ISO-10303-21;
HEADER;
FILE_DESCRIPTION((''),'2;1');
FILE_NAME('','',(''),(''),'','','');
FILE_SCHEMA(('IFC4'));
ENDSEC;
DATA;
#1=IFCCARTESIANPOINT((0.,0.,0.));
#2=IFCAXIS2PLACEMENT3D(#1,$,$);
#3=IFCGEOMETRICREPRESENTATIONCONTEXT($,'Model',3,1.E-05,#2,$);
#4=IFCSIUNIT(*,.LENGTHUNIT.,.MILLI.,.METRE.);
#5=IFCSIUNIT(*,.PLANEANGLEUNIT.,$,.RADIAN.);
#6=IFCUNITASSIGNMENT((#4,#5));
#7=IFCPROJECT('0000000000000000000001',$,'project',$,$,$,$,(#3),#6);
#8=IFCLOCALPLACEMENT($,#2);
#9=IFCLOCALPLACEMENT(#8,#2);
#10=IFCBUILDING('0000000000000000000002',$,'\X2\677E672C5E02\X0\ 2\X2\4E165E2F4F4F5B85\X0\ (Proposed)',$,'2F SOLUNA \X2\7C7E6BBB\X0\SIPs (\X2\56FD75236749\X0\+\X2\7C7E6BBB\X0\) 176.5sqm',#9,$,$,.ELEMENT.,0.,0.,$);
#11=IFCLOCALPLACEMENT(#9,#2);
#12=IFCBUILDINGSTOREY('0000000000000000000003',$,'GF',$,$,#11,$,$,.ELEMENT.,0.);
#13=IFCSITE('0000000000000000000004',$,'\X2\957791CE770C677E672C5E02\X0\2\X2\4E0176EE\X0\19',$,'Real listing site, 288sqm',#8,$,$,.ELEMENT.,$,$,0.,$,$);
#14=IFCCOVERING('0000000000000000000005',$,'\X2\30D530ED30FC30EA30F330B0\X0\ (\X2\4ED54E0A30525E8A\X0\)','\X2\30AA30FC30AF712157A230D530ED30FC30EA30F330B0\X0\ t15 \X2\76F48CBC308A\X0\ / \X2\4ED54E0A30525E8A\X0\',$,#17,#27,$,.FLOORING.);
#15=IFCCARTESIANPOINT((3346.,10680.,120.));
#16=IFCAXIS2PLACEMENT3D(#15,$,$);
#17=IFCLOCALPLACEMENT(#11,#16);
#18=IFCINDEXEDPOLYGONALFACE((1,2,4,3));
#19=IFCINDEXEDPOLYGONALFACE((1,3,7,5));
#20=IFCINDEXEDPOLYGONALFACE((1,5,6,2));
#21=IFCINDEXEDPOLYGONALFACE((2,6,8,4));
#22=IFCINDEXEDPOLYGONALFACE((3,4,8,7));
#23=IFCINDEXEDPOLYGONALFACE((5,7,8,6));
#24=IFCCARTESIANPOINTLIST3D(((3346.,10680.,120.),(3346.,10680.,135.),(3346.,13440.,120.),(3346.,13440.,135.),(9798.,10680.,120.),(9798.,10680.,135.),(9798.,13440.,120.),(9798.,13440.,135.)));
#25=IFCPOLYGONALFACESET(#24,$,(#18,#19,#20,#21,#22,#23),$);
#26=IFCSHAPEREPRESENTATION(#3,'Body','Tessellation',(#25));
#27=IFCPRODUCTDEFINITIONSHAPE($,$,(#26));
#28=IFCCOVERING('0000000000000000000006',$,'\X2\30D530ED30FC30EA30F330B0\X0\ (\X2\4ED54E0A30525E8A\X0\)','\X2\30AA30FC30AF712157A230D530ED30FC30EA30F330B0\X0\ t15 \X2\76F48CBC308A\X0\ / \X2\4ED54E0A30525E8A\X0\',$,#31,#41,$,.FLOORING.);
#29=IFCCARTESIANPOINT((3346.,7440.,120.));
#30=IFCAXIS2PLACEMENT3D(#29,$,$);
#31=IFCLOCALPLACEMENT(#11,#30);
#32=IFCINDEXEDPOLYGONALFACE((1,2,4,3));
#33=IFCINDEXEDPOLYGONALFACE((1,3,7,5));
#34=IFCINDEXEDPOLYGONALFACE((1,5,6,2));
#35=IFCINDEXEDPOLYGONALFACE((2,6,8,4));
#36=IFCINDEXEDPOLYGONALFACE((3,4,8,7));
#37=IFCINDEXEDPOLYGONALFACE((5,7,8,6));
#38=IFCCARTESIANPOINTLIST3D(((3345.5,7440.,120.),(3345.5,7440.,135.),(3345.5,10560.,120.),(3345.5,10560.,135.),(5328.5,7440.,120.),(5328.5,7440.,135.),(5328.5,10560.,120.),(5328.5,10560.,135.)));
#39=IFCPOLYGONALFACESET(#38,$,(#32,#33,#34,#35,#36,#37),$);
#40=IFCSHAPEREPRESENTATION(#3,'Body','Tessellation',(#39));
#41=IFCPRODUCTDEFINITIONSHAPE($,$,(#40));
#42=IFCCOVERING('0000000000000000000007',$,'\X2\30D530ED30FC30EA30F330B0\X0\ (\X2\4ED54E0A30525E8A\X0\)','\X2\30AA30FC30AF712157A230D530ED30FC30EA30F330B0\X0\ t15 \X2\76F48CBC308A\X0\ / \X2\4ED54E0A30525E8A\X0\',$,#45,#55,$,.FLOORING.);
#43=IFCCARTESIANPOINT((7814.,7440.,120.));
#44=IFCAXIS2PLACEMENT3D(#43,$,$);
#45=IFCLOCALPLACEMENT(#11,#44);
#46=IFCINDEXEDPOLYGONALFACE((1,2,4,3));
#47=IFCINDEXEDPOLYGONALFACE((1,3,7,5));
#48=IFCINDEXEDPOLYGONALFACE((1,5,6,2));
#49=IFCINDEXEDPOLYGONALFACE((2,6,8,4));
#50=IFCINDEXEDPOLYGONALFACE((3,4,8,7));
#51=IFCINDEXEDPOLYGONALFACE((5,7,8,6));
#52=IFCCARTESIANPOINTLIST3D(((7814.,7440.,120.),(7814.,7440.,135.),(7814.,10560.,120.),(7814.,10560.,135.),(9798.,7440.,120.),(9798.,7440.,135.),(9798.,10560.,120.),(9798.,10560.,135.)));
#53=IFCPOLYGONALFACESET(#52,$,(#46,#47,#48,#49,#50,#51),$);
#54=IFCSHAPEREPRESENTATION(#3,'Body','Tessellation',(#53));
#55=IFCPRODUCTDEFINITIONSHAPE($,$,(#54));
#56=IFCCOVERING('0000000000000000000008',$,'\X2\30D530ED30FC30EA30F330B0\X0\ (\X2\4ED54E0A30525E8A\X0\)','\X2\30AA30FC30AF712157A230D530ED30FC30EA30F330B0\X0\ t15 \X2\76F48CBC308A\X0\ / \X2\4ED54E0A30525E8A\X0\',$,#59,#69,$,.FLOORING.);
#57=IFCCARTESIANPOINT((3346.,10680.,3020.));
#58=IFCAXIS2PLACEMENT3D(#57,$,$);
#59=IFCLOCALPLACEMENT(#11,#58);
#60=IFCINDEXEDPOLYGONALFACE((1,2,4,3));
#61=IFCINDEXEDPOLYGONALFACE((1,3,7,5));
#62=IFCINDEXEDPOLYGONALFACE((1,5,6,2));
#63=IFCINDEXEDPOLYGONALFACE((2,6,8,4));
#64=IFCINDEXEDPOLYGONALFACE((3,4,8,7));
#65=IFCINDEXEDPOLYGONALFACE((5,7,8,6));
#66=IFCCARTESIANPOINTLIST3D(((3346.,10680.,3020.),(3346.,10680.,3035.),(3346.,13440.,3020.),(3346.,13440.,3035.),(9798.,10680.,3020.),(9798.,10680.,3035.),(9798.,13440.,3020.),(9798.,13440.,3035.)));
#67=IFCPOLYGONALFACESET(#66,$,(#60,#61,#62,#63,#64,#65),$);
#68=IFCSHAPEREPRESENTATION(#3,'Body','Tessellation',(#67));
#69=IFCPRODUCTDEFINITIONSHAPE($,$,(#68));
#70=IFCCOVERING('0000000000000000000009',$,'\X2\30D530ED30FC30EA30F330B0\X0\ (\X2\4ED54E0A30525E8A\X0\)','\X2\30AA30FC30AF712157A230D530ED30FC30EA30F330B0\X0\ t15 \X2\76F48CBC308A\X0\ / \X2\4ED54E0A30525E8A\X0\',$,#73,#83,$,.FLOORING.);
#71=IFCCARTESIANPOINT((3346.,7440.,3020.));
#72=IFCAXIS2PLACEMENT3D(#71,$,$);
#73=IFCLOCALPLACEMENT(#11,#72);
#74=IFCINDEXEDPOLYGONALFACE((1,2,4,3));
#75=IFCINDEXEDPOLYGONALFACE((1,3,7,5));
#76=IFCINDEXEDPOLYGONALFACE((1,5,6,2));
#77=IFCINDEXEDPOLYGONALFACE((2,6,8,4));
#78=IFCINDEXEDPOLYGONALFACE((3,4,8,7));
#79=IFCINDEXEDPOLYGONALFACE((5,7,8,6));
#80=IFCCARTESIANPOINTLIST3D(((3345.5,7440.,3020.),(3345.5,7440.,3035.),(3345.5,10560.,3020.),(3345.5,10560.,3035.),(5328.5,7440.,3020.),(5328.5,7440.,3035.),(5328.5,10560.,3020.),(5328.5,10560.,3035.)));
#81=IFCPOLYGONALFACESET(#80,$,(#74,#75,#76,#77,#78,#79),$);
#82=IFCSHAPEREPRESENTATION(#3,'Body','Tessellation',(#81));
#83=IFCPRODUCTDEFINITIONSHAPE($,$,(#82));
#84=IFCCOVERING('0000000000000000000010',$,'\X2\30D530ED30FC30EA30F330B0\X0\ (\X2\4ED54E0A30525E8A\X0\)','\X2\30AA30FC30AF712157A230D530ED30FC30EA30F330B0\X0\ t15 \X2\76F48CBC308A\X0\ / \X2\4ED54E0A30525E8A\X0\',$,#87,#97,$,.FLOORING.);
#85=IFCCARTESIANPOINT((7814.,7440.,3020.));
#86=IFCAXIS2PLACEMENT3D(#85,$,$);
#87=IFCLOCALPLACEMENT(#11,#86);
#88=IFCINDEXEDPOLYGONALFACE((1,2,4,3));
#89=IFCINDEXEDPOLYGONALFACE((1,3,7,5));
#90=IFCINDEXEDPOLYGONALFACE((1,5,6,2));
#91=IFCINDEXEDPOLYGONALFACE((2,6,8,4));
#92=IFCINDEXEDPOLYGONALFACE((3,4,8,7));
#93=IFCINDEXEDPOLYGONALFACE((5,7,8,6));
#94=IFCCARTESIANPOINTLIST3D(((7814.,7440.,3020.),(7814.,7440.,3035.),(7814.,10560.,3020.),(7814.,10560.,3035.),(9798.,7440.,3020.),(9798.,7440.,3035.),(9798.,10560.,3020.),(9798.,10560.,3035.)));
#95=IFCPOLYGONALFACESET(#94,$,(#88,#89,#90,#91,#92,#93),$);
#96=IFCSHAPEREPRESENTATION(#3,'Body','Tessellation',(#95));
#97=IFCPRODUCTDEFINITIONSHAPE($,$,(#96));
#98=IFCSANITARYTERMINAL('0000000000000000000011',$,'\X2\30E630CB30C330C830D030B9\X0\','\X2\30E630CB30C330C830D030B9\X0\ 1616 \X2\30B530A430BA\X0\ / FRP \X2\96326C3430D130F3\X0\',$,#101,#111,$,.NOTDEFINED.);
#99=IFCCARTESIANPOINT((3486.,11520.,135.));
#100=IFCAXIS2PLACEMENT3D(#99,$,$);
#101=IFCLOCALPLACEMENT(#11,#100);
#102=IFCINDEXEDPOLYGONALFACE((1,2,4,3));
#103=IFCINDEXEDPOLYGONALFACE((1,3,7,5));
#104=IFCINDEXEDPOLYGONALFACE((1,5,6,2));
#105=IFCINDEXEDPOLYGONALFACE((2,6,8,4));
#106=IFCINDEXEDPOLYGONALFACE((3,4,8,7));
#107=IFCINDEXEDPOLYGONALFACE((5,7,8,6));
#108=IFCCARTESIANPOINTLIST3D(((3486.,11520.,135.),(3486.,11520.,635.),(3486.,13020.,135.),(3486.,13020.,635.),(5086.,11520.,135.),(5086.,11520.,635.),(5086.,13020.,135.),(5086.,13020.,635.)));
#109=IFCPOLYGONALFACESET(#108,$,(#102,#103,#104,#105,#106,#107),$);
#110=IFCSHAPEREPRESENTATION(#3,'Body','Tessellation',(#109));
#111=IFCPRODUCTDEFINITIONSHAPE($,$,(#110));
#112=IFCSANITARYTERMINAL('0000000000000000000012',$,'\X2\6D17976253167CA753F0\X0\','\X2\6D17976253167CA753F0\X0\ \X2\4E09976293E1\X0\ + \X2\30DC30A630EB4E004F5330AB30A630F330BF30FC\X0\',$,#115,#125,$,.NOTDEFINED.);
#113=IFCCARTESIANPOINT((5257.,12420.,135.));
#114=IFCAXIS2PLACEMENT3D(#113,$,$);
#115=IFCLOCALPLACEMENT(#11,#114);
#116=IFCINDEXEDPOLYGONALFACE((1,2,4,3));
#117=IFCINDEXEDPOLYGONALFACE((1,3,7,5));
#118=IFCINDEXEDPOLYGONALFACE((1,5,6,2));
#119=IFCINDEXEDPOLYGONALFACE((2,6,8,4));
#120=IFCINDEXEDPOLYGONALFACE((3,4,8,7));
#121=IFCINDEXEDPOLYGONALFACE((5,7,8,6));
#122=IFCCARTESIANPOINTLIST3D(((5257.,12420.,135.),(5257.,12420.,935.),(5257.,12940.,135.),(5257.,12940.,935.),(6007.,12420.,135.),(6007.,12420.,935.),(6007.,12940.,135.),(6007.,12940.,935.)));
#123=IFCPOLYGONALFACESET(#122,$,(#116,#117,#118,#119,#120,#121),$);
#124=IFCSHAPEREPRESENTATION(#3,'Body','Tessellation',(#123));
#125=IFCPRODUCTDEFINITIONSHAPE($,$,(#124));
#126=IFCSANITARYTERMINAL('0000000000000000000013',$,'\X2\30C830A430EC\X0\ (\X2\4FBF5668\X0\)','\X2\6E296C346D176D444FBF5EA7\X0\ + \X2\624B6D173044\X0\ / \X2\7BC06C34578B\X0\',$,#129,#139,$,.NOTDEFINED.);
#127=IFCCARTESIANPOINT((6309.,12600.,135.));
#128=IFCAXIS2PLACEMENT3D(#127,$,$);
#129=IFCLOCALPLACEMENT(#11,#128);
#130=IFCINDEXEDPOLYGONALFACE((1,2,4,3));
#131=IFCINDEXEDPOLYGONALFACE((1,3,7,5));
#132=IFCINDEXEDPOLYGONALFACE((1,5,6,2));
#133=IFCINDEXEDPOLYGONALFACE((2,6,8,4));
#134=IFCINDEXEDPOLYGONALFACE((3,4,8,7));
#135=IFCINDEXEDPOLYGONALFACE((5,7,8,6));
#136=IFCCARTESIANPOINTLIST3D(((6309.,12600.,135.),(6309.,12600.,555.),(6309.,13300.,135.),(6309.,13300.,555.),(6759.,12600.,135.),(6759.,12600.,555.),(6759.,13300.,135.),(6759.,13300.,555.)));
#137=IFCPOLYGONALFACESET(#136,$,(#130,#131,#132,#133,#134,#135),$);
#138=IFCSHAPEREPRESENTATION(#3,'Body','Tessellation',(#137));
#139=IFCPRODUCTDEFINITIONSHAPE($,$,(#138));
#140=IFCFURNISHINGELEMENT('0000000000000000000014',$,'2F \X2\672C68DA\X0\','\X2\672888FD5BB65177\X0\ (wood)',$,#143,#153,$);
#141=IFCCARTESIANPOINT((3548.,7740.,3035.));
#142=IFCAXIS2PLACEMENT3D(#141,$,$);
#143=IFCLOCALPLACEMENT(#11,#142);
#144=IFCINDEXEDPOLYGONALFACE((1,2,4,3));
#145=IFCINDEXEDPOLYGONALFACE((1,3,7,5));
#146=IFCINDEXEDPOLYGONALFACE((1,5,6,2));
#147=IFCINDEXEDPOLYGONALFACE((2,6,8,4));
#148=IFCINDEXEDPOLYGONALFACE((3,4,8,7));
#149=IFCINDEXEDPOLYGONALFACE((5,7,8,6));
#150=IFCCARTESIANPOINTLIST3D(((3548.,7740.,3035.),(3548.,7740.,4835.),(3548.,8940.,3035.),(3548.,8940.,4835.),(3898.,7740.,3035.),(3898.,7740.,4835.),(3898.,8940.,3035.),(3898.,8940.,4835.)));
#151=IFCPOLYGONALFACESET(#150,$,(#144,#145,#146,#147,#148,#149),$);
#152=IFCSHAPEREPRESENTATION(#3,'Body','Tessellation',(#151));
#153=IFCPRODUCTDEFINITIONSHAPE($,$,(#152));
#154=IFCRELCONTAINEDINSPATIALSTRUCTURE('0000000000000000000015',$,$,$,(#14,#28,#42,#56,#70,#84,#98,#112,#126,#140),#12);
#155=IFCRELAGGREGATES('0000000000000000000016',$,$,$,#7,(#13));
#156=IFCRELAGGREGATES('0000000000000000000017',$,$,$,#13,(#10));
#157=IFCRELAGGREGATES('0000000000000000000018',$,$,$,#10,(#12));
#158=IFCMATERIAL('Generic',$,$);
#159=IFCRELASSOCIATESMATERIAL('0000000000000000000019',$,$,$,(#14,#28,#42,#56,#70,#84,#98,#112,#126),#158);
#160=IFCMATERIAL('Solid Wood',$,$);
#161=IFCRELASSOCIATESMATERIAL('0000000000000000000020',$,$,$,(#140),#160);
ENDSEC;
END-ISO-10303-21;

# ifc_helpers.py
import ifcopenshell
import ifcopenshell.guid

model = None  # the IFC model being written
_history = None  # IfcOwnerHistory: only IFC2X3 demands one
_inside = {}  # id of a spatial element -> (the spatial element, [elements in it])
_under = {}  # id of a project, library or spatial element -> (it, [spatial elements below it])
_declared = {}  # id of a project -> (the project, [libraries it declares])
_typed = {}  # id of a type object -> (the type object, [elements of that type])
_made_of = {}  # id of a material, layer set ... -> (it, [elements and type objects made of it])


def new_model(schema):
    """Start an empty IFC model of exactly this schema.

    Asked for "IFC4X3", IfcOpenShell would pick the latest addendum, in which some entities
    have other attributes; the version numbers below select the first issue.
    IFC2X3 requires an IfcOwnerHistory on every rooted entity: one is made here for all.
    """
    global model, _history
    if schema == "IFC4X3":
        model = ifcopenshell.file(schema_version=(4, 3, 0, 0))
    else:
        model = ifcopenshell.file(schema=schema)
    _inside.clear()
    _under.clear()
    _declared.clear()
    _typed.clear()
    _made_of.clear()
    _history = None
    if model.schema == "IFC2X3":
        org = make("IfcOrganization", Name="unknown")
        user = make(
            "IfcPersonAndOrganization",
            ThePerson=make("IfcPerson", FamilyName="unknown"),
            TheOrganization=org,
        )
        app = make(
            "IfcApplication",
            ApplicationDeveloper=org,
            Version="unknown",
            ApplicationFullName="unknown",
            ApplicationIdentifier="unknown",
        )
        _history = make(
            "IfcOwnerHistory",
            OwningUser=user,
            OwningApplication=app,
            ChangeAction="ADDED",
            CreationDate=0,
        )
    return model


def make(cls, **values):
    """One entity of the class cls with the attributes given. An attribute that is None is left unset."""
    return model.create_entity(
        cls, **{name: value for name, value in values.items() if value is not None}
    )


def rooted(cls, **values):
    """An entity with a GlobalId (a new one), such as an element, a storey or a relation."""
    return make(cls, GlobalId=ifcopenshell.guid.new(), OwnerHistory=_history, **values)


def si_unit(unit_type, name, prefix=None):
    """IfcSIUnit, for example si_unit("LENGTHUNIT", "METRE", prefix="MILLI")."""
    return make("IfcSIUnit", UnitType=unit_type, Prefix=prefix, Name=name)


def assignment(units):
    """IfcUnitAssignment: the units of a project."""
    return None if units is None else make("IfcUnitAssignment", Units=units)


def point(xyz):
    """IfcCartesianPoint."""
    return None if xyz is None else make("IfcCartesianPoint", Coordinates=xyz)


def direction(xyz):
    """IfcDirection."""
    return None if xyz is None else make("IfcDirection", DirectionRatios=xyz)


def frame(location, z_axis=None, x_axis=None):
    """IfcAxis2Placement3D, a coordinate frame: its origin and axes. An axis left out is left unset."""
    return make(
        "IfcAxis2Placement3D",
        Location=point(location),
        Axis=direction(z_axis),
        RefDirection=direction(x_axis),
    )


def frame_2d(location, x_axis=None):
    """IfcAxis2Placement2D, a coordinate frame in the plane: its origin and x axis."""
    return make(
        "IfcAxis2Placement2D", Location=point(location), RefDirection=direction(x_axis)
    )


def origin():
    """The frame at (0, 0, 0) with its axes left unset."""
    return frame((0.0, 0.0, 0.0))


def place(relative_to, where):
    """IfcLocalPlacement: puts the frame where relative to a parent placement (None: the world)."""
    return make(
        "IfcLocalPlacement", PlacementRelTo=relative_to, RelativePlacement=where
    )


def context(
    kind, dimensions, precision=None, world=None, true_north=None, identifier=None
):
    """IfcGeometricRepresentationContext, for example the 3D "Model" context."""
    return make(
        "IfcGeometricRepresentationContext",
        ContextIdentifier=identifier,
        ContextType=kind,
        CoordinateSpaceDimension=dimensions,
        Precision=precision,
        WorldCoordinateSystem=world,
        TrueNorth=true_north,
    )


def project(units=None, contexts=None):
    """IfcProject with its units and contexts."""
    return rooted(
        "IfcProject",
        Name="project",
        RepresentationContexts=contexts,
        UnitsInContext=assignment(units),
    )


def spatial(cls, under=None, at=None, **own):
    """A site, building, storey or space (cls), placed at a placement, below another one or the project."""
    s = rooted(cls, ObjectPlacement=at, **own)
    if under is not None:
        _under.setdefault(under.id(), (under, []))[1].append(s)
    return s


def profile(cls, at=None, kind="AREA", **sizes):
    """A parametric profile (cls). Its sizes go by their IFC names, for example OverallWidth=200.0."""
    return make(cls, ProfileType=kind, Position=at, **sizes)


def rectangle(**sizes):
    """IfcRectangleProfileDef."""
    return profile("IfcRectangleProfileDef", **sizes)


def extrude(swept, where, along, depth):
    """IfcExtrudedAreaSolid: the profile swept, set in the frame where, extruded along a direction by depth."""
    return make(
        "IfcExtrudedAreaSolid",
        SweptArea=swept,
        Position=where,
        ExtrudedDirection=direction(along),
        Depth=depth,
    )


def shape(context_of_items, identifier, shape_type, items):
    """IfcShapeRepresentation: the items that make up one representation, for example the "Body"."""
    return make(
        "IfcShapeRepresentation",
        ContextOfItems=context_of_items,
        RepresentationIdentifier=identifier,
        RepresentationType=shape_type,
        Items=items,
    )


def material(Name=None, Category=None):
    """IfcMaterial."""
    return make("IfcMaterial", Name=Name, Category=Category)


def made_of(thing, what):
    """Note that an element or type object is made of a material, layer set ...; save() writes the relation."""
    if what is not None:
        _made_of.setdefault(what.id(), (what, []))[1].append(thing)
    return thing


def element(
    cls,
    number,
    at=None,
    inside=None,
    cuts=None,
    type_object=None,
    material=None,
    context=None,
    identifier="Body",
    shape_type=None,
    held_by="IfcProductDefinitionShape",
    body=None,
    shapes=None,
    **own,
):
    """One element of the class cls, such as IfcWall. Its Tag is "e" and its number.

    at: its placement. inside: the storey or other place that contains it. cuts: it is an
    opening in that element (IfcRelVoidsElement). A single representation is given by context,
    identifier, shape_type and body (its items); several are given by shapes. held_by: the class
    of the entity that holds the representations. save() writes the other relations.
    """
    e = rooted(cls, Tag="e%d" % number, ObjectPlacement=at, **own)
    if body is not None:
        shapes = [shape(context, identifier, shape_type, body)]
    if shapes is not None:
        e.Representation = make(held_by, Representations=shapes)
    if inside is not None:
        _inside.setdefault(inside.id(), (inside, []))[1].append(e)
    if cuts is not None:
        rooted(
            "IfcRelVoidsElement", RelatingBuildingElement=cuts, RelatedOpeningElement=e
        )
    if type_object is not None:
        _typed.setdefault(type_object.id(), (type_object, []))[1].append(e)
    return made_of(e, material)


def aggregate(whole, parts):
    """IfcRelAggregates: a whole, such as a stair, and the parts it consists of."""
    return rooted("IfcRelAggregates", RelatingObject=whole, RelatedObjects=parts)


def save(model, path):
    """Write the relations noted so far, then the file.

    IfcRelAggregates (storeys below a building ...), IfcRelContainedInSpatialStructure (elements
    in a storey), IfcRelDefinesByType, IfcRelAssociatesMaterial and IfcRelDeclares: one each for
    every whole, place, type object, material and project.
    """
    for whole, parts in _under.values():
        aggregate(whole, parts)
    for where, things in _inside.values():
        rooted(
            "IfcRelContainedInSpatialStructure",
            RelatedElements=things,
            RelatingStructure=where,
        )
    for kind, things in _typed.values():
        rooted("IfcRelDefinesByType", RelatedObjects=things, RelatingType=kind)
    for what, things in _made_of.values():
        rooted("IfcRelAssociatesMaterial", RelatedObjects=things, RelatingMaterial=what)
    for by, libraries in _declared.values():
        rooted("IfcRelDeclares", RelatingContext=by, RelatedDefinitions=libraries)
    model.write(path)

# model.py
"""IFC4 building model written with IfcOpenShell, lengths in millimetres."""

from ifc_helpers import new_model, si_unit, frame, frame_2d, origin, place, context, project, spatial, rectangle, extrude, material, element, save


model = new_model("IFC4")

# Units and contexts
model_context = context("Model", 3, precision=1e-05, world=origin())
ifc_project = project(units=[si_unit("LENGTHUNIT", "METRE", prefix="MILLI"), si_unit("PLANEANGLEUNIT", "RADIAN")], contexts=[model_context])

# Site, building, storey
site_placement = place(None, origin())
site = spatial("IfcSite", under=ifc_project, at=site_placement, Name="長野県松本市2丁目19", ObjectType="Real listing site, 288sqm", CompositionType="ELEMENT", RefElevation=0.0)
building_placement = place(site_placement, origin())
building = spatial("IfcBuilding", under=site, at=building_placement, Name="松本市 2世帯住宅 (Proposed)", ObjectType="2F SOLUNA 籾殻SIPs (国産杉+籾殻) 176.5sqm", CompositionType="ELEMENT", ElevationOfRefHeight=0.0, ElevationOfTerrain=0.0)
storey_placement = place(building_placement, origin())
storey = spatial("IfcBuildingStorey", under=building, at=storey_placement, Name="GF", CompositionType="ELEMENT", Elevation=0.0)

# Shared definitions
ifc_material_1 = material(Name="Solid Wood")
ifc_material_2 = material(Name="Generic")

# Coverings
covering_1_placement = place(storey_placement, frame((3346.0, 10680.0, 120.0)))
element("IfcCovering", 1, at=covering_1_placement, inside=storey, material=ifc_material_2, Name="フローリング (仕上げ床)", Description="オーク無垢フローリング t15 直貼り / 仕上げ床", PredefinedType="FLOORING", context=model_context, shape_type="SweptSolid", body=[
    extrude(rectangle(XDim=6452.0, YDim=2760.0, at=frame_2d((3226.0, 1380.0))), frame((3346.0, 10680.0, 120.0)), (0.0, 0.0, 1.0), 15.0),
])
covering_2_placement = place(storey_placement, frame((3346.0, 7440.0, 120.0)))
element("IfcCovering", 2, at=covering_2_placement, inside=storey, material=ifc_material_2, Name="フローリング (仕上げ床)", Description="オーク無垢フローリング t15 直貼り / 仕上げ床", PredefinedType="FLOORING", context=model_context, shape_type="SweptSolid", body=[
    extrude(rectangle(XDim=1983.0, YDim=3120.0, at=frame_2d((991.0, 1560.0))), frame((3346.0, 7440.0, 120.0)), (0.0, 0.0, 1.0), 15.0),
])
covering_3_placement = place(storey_placement, frame((7814.0, 7440.0, 120.0)))
element("IfcCovering", 3, at=covering_3_placement, inside=storey, material=ifc_material_2, Name="フローリング (仕上げ床)", Description="オーク無垢フローリング t15 直貼り / 仕上げ床", PredefinedType="FLOORING", context=model_context, shape_type="SweptSolid", body=[
    extrude(rectangle(XDim=1984.0, YDim=3120.0, at=frame_2d((992.0, 1560.0))), frame((7814.0, 7440.0, 120.0)), (0.0, 0.0, 1.0), 15.0),
])
covering_4_placement = place(storey_placement, frame((3346.0, 10680.0, 3020.0)))
element("IfcCovering", 4, at=covering_4_placement, inside=storey, material=ifc_material_2, Name="フローリング (仕上げ床)", Description="オーク無垢フローリング t15 直貼り / 仕上げ床", PredefinedType="FLOORING", context=model_context, shape_type="SweptSolid", body=[
    extrude(rectangle(XDim=6452.0, YDim=2760.0, at=frame_2d((3226.0, 1380.0))), frame((3346.0, 10680.0, 3020.0)), (0.0, 0.0, 1.0), 15.0),
])
covering_5_placement = place(storey_placement, frame((3346.0, 7440.0, 3020.0)))
element("IfcCovering", 5, at=covering_5_placement, inside=storey, material=ifc_material_2, Name="フローリング (仕上げ床)", Description="オーク無垢フローリング t15 直貼り / 仕上げ床", PredefinedType="FLOORING", context=model_context, shape_type="SweptSolid", body=[
    extrude(rectangle(XDim=1983.0, YDim=3120.0, at=frame_2d((991.0, 1560.0))), frame((3346.0, 7440.0, 3020.0)), (0.0, 0.0, 1.0), 15.0),
])
covering_6_placement = place(storey_placement, frame((7814.0, 7440.0, 3020.0)))
element("IfcCovering", 6, at=covering_6_placement, inside=storey, material=ifc_material_2, Name="フローリング (仕上げ床)", Description="オーク無垢フローリング t15 直貼り / 仕上げ床", PredefinedType="FLOORING", context=model_context, shape_type="SweptSolid", body=[
    extrude(rectangle(XDim=1984.0, YDim=3120.0, at=frame_2d((992.0, 1560.0))), frame((7814.0, 7440.0, 3020.0)), (0.0, 0.0, 1.0), 15.0),
])

# Sanitary terminals
sanitary_terminal_1_placement = place(storey_placement, frame((3486.0, 11520.0, 135.0)))
element("IfcSanitaryTerminal", 7, at=sanitary_terminal_1_placement, inside=storey, material=ifc_material_2, Name="ユニットバス", Description="ユニットバス 1616 サイズ / FRP 防水パン", PredefinedType="NOTDEFINED", context=model_context, shape_type="SweptSolid", body=[
    extrude(rectangle(XDim=1600.0, YDim=1500.0, at=frame_2d((800.0, 750.0))), frame((3486.0, 11520.0, 135.0)), (0.0, 0.0, 1.0), 500.0),
])
sanitary_terminal_2_placement = place(storey_placement, frame((5257.0, 12420.0, 135.0)))
element("IfcSanitaryTerminal", 8, at=sanitary_terminal_2_placement, inside=storey, material=ifc_material_2, Name="洗面化粧台", Description="洗面化粧台 三面鏡 + ボウル一体カウンター", PredefinedType="NOTDEFINED", context=model_context, shape_type="SweptSolid", body=[
    extrude(rectangle(XDim=750.0, YDim=520.0, at=frame_2d((375.0, 260.0))), frame((5257.0, 12420.0, 135.0)), (0.0, 0.0, 1.0), 800.0),
])
sanitary_terminal_3_placement = place(storey_placement, frame((6309.0, 12600.0, 135.0)))
element("IfcSanitaryTerminal", 9, at=sanitary_terminal_3_placement, inside=storey, material=ifc_material_2, Name="トイレ (便器)", Description="温水洗浄便座 + 手洗い / 節水型", PredefinedType="NOTDEFINED", context=model_context, shape_type="SweptSolid", body=[
    extrude(rectangle(XDim=450.0, YDim=700.0, at=frame_2d((225.0, 350.0))), frame((6309.0, 12600.0, 135.0)), (0.0, 0.0, 1.0), 420.0),
])

# Furnishing element
furnishing_placement = place(storey_placement, frame((3548.0, 7740.0, 3035.0)))
element("IfcFurnishingElement", 10, at=furnishing_placement, inside=storey, material=ifc_material_1, Name="2F 本棚", Description="木製家具 (wood)", context=model_context, shape_type="SweptSolid", body=[
    extrude(rectangle(XDim=350.0, YDim=1200.0, at=frame_2d((175.0, 600.0))), frame((3548.0, 7740.0, 3035.0)), (0.0, 0.0, 1.0), 1800.0),
])

save(model, "model.ifc")
